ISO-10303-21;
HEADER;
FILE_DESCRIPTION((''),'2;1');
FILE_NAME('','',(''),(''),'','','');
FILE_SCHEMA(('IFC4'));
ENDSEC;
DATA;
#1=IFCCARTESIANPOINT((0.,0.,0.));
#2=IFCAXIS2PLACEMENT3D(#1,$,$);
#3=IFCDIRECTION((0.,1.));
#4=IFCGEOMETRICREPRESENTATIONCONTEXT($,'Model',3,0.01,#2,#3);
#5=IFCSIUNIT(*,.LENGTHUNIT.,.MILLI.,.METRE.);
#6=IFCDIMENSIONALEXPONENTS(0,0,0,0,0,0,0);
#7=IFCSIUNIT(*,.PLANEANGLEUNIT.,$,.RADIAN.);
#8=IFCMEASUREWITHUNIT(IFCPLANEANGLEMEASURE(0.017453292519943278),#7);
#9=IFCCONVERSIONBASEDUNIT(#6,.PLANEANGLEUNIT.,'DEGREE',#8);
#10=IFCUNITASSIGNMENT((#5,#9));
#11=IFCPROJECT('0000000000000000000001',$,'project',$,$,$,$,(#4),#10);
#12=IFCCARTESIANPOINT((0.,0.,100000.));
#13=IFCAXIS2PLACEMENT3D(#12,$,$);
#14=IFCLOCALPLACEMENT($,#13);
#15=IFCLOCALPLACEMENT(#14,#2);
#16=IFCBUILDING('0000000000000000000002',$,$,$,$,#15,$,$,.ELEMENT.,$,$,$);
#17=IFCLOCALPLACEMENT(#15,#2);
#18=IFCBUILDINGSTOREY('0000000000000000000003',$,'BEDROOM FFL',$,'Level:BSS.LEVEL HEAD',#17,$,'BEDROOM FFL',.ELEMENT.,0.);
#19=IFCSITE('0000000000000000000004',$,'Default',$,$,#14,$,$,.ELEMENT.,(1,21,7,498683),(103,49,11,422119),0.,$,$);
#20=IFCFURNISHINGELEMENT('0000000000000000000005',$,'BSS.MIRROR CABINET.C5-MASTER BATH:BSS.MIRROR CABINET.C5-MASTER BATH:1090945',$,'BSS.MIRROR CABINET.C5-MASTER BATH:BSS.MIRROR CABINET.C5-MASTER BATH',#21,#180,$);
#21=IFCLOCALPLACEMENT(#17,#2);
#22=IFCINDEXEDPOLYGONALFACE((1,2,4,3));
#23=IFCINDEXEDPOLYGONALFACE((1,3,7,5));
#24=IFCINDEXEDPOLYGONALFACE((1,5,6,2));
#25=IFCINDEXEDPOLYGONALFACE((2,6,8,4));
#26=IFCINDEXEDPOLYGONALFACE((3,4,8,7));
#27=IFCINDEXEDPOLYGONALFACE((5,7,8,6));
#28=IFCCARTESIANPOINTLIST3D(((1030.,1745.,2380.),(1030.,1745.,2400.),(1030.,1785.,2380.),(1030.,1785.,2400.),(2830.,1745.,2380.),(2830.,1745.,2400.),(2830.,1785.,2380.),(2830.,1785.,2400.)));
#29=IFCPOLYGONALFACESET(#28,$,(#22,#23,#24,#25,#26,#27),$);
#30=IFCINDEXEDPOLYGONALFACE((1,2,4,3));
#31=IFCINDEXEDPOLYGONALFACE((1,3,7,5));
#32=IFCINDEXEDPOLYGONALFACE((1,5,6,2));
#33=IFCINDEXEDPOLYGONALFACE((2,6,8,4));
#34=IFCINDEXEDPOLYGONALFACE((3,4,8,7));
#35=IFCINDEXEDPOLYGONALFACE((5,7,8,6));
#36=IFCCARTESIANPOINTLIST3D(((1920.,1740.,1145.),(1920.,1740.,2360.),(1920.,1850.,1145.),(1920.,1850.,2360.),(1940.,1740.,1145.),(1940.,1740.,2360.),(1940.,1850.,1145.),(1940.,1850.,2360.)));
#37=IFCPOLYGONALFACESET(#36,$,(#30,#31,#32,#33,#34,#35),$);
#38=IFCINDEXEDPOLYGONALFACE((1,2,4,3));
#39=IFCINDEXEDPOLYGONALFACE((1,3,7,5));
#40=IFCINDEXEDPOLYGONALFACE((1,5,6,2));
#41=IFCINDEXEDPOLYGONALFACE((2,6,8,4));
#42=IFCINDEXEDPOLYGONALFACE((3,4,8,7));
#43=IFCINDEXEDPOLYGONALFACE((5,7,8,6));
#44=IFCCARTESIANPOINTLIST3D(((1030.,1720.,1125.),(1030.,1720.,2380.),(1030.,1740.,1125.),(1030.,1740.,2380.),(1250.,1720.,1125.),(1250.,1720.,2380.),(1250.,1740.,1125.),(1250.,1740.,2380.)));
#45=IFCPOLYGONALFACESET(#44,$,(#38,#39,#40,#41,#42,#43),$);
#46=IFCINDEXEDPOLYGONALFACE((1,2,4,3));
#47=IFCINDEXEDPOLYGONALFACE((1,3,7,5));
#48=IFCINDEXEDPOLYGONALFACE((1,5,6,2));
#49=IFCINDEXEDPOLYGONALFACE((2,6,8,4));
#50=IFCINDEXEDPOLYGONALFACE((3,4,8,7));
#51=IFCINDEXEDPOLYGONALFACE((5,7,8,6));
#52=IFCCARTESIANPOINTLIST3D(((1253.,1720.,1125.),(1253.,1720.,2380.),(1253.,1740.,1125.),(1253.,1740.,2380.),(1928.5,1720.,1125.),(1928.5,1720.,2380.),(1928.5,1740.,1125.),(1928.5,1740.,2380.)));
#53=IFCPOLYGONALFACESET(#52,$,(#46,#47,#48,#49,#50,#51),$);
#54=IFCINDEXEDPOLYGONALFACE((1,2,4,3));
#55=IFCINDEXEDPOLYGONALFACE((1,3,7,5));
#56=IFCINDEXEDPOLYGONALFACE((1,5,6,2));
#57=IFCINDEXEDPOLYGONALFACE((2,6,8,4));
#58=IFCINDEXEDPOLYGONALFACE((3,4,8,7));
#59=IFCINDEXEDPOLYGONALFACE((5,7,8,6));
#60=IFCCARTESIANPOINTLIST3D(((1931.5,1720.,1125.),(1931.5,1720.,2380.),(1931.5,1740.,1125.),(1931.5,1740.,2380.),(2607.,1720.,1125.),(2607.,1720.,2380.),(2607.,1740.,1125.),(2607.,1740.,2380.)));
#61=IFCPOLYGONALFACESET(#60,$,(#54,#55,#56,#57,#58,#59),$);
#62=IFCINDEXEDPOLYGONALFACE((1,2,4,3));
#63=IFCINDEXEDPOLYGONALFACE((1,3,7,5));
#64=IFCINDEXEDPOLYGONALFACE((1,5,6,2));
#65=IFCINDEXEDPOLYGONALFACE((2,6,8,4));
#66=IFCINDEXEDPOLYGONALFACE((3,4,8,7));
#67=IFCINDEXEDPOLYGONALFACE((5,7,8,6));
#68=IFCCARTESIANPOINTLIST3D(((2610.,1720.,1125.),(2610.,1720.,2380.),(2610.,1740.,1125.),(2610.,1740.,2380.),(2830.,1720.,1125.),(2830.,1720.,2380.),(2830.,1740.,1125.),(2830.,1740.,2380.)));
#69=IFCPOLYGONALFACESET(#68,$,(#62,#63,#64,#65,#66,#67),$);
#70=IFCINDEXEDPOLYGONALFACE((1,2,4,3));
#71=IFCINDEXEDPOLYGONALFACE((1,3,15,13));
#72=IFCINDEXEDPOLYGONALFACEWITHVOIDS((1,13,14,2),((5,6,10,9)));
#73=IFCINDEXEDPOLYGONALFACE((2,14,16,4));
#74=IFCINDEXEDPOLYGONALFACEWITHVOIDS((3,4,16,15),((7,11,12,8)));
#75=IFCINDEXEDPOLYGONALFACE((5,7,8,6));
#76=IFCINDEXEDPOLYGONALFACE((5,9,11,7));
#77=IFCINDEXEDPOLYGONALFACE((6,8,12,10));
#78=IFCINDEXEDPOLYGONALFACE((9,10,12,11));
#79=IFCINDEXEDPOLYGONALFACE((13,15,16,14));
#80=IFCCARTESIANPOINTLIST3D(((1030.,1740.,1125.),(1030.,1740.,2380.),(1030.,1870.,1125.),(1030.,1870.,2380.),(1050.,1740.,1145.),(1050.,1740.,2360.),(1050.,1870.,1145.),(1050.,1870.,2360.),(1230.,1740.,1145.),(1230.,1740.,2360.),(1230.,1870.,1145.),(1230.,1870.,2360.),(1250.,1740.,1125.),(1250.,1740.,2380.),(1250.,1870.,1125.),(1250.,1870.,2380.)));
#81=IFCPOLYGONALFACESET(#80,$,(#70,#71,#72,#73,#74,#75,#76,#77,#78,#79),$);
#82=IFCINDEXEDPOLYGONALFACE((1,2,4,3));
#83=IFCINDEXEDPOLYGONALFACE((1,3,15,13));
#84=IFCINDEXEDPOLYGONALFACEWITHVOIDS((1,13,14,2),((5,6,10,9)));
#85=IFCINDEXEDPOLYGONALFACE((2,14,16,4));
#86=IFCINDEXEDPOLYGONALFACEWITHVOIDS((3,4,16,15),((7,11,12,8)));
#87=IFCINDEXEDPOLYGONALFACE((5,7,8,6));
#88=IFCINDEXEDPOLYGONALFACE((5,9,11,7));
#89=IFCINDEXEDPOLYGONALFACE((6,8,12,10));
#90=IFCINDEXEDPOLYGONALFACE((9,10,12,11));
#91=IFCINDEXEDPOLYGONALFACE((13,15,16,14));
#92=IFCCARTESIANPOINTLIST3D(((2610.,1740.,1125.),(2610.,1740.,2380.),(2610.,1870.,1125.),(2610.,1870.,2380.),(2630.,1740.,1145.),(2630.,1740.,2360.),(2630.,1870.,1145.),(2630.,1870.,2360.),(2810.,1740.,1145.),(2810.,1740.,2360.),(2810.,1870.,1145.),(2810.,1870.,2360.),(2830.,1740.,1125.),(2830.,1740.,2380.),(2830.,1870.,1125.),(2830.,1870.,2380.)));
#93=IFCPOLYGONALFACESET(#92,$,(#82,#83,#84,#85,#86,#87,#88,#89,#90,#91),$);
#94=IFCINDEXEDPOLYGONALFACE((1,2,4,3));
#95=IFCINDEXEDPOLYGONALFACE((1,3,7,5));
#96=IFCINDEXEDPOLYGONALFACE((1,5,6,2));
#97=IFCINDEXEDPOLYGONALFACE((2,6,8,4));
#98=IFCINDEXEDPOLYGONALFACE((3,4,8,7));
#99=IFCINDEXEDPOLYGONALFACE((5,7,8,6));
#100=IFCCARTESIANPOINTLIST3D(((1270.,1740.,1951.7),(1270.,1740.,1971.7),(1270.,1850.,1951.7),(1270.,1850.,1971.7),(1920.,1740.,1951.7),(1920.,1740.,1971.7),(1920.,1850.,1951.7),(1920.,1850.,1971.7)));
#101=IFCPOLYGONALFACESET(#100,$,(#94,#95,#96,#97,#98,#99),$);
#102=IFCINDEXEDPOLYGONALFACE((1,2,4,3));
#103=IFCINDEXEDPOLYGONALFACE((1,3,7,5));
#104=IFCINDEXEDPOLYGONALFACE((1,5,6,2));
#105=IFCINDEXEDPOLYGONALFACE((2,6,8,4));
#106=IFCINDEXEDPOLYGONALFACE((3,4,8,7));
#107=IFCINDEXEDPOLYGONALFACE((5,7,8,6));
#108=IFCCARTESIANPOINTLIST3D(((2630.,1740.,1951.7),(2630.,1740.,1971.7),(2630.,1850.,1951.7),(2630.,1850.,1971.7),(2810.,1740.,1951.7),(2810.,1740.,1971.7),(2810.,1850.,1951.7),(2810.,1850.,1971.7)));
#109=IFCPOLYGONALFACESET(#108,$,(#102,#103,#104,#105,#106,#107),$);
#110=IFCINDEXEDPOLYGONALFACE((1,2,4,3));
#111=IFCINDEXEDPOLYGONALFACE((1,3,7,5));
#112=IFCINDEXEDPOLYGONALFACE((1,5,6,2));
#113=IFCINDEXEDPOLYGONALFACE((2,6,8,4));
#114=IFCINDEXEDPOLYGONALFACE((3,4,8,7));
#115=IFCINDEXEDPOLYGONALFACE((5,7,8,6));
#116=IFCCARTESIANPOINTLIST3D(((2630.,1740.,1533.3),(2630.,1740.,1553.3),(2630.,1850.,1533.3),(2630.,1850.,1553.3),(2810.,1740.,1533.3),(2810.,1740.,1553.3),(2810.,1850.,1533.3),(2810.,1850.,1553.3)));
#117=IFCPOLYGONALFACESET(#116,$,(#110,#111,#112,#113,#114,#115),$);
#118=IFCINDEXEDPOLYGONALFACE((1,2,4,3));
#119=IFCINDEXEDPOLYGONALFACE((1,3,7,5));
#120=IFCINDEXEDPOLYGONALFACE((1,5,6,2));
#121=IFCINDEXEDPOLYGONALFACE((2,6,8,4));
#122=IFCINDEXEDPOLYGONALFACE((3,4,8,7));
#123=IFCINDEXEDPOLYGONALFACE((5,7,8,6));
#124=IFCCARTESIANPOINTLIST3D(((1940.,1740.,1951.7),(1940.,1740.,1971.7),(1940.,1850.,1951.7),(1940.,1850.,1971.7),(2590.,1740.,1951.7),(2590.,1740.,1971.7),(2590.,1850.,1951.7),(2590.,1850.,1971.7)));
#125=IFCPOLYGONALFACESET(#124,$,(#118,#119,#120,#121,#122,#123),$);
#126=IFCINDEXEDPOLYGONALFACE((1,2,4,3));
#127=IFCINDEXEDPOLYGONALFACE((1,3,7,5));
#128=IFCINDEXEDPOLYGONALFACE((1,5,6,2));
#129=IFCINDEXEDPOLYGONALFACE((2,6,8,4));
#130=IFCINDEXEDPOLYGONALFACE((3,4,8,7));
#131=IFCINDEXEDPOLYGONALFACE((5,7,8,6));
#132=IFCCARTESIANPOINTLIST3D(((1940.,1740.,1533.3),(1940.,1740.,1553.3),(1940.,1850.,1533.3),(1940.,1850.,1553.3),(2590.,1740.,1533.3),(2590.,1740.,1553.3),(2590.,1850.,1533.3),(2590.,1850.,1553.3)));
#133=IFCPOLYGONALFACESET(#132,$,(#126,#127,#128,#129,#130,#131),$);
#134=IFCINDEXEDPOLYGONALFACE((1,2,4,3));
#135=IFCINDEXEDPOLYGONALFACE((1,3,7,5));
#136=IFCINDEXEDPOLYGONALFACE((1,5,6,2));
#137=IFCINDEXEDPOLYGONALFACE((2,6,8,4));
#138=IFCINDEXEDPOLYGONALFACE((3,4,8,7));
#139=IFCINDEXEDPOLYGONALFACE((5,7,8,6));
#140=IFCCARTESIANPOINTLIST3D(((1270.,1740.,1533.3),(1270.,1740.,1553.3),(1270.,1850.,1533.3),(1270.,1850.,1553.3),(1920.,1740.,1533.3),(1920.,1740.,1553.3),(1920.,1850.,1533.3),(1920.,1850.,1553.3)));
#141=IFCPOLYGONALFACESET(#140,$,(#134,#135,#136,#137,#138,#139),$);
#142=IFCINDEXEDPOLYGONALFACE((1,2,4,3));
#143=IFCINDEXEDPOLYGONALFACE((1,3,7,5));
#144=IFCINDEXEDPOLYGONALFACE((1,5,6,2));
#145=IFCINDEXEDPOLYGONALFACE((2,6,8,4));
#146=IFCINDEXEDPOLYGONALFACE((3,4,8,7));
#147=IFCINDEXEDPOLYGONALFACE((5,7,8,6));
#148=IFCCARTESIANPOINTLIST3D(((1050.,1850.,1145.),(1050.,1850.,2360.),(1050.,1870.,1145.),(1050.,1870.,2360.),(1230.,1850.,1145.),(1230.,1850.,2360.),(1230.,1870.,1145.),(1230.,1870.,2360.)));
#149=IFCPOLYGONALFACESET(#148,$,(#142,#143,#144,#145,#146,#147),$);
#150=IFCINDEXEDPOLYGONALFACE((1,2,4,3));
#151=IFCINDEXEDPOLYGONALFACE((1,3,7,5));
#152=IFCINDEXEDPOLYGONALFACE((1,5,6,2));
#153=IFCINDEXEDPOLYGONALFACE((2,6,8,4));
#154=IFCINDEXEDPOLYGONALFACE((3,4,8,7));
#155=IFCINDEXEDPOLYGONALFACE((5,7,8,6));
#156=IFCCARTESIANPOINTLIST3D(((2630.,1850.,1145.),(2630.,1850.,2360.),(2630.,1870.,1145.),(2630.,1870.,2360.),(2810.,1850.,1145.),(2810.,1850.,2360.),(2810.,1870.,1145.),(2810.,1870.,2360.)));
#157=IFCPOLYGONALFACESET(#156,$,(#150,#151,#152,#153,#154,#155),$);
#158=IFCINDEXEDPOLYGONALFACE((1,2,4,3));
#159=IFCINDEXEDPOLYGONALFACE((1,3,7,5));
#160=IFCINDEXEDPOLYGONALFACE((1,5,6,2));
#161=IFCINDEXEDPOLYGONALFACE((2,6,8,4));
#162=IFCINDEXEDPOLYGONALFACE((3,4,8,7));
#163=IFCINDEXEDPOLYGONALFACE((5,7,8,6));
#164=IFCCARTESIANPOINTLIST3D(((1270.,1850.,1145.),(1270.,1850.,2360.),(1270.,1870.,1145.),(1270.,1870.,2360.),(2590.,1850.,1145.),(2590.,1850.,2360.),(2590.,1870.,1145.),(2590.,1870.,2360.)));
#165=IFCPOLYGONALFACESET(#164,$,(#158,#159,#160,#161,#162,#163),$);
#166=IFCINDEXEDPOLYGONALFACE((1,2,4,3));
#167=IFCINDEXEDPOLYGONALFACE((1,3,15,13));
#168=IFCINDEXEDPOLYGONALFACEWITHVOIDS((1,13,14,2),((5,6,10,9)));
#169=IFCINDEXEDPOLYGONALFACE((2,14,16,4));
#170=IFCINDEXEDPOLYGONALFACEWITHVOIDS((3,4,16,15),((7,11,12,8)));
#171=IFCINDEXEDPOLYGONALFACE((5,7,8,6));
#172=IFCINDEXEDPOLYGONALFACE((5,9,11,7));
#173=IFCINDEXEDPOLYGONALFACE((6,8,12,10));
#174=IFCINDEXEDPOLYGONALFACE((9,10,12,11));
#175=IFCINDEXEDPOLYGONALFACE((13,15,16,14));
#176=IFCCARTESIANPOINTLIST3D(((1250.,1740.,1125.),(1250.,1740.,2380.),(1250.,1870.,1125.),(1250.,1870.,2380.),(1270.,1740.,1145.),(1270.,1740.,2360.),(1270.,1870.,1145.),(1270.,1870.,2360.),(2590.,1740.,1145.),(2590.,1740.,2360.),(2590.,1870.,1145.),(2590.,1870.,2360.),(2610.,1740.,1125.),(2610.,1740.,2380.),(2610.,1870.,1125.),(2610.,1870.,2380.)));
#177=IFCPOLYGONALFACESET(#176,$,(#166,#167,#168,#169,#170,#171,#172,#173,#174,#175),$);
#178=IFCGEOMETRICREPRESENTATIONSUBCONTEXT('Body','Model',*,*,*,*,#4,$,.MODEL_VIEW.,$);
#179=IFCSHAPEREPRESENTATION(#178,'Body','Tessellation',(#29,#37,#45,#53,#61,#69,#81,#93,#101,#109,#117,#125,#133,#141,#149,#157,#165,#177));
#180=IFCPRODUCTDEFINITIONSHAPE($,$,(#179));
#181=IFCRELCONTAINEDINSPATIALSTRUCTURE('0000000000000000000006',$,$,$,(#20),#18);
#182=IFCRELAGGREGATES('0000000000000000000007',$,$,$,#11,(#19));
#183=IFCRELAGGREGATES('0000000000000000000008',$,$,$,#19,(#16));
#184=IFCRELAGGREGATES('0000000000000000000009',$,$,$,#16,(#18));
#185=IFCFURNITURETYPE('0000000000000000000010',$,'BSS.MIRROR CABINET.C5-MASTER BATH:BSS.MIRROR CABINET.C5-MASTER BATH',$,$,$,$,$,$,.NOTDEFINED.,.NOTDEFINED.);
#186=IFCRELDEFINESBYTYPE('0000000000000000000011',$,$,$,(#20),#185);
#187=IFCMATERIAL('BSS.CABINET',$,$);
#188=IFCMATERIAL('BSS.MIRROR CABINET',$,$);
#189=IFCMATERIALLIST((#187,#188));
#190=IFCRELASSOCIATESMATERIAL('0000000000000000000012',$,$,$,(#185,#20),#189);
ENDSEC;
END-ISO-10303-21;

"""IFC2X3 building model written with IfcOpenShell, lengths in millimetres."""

from ifc_helpers import new_model, entity, si_unit, converted_unit, direction, frame, frame_2d, origin, origin_2d_with_axis, place, context, subcontext, project, spatial, polyline, rectangle, outline, extrude, source, transform, mapped, material, material_list, type_object, type_shapes, element, save


model = new_model("IFC2X3")

# Units and contexts
model_context = context("Model", 3, precision=0.01, world=origin(), true_north=direction((0.0, 1.0)))
body_context = subcontext(model_context, "Body", "Model", "MODEL_VIEW")
ifc_project = project(units=[si_unit("LENGTHUNIT", "METRE", prefix="MILLI"), converted_unit("PLANEANGLEUNIT", "DEGREE", entity("IfcPlaneAngleMeasure", 0.017453292519943278), si_unit("PLANEANGLEUNIT", "RADIAN"), dimensions=[0, 0, 0, 0, 0, 0, 0])], contexts=[model_context])

# Site, building, storey
site_placement = place(None, frame((0.0, 0.0, 100000.0)))
site = spatial("IfcSite", under=ifc_project, at=site_placement, Name="Default", CompositionType="ELEMENT", RefLatitude=(1, 21, 7, 498683), RefLongitude=(103, 49, 11, 422119), RefElevation=0.0)
building_placement = place(site_placement, origin())
building = spatial("IfcBuilding", under=site, at=building_placement, CompositionType="ELEMENT")
storey_placement = place(building_placement, origin())
storey = spatial("IfcBuildingStorey", under=building, at=storey_placement, Name="BEDROOM FFL", ObjectType="Level:BSS.LEVEL HEAD", LongName="BEDROOM FFL", CompositionType="ELEMENT", Elevation=0.0)

# Furnishing element
ifc_material_1 = material(Name="BSS.CABINET")
ifc_material_2 = material(Name="BSS.MIRROR CABINET")
ifc_material_list = material_list([ifc_material_1, ifc_material_2])
furniture_type = type_object("IfcFurnitureType", Name="BSS.MIRROR CABINET.C5-MASTER BATH:BSS.MIRROR CABINET.C5-MASTER BATH", AssemblyPlace="NOTDEFINED", material=ifc_material_list)
shared_shape_1 = source(origin(), body_context, "Body", "SweptSolid", [
    extrude(rectangle(XDim=40.0, YDim=1800.0, at=frame_2d((0.0, 0.0), x_axis=(1.0, 0.0))), frame((0.0, 105.0, 1255.0), z_axis=(0.0, 0.0, 1.0), x_axis=(0.0, 1.0, 0.0)), (0.0, 0.0, 1.0), 20.0),
    extrude(rectangle(XDim=20.0, YDim=110.0, at=frame_2d((0.0, 0.0), x_axis=(1.0, 0.0))), frame((0.0, 75.0, 20.0), z_axis=(0.0, 0.0, 1.0), x_axis=(-1.0, 0.0, 0.0)), (0.0, 0.0, 1.0), 1215.0),
    extrude(rectangle(XDim=220.0, YDim=20.0, at=frame_2d((0.0, 0.0), x_axis=(1.0, 0.0))), frame((790.0, 140.0, 0.0), z_axis=(0.0, 0.0, 1.0), x_axis=(-1.0, 0.0, 0.0)), (0.0, 0.0, 1.0), 1255.0),
    extrude(rectangle(XDim=675.5, YDim=20.0, at=frame_2d((0.0, 0.0), x_axis=(1.0, 0.0))), frame((339.2, 140.0, 0.0), z_axis=(0.0, 0.0, 1.0), x_axis=(-1.0, 0.0, 0.0)), (0.0, 0.0, 1.0), 1255.0),
    extrude(rectangle(XDim=675.5, YDim=20.0, at=frame_2d((0.0, 0.0), x_axis=(1.0, 0.0))), frame((-339.3, 140.0, 0.0), z_axis=(0.0, 0.0, 1.0), x_axis=(-1.0, 0.0, 0.0)), (0.0, 0.0, 1.0), 1255.0),
    extrude(rectangle(XDim=220.0, YDim=20.0, at=frame_2d((0.0, 0.0), x_axis=(1.0, 0.0))), frame((-790.0, 140.0, 0.0), z_axis=(0.0, 0.0, 1.0), x_axis=(-1.0, 0.0, 0.0)), (0.0, 0.0, 1.0), 1255.0),
    extrude(outline(polyline([(-627.5, -110.0), (627.5, -110.0), (627.5, 110.0), (-627.5, 110.0), (-627.5, -110.0)]), holes=[polyline([(607.5, 90.0), (607.5, -90.0), (-607.5, -90.0), (-607.5, 90.0), (607.5, 90.0)])]), frame((790.0, 0.0, 627.5), z_axis=(0.0, 1.0, 0.0), x_axis=(0.0, 0.0, -1.0)), (0.0, 0.0, 1.0), 130.0),
    extrude(outline(polyline([(-627.5, -110.0), (627.5, -110.0), (627.5, 110.0), (-627.5, 110.0), (-627.5, -110.0)]), holes=[polyline([(607.5, 90.0), (607.5, -90.0), (-607.5, -90.0), (-607.5, 90.0), (607.5, 90.0)])]), frame((-790.0, 0.0, 627.5), z_axis=(0.0, 1.0, 0.0), x_axis=(0.0, 0.0, -1.0)), (0.0, 0.0, 1.0), 130.0),
    extrude(rectangle(XDim=650.0, YDim=110.0, at=origin_2d_with_axis()), frame((335.0, 75.0, 826.7), z_axis=(0.0, 0.0, 1.0), x_axis=(-1.0, 0.0, 0.0)), (0.0, 0.0, 1.0), 20.0),
    extrude(rectangle(XDim=180.0, YDim=110.0, at=origin_2d_with_axis()), frame((-790.0, 75.0, 826.7), z_axis=(0.0, 0.0, 1.0), x_axis=(-1.0, 0.0, 0.0)), (0.0, 0.0, 1.0), 20.0),
    extrude(rectangle(XDim=180.0, YDim=110.0, at=origin_2d_with_axis()), frame((-790.0, 75.0, 408.3), z_axis=(0.0, 0.0, 1.0), x_axis=(-1.0, 0.0, 0.0)), (0.0, 0.0, 1.0), 20.0),
    extrude(rectangle(XDim=650.0, YDim=110.0, at=origin_2d_with_axis()), frame((-335.0, 75.0, 826.7), z_axis=(0.0, 0.0, 1.0), x_axis=(-1.0, 0.0, 0.0)), (0.0, 0.0, 1.0), 20.0),
    extrude(rectangle(XDim=650.0, YDim=110.0, at=frame_2d((0.0, 0.0), x_axis=(1.0, 0.0))), frame((-335.0, 75.0, 408.3), z_axis=(0.0, 0.0, 1.0), x_axis=(-1.0, 0.0, 0.0)), (0.0, 0.0, 1.0), 20.0),
    extrude(rectangle(XDim=650.0, YDim=110.0, at=origin_2d_with_axis()), frame((335.0, 75.0, 408.3), z_axis=(0.0, 0.0, 1.0), x_axis=(-1.0, 0.0, 0.0)), (0.0, 0.0, 1.0), 20.0),
    extrude(rectangle(XDim=180.0, YDim=20.0, at=origin_2d_with_axis()), frame((790.0, 10.0, 20.0), z_axis=(0.0, 0.0, 1.0), x_axis=(-1.0, 0.0, 0.0)), (0.0, 0.0, 1.0), 1215.0),
    extrude(rectangle(XDim=180.0, YDim=20.0, at=origin_2d_with_axis()), frame((-790.0, 10.0, 20.0), z_axis=(0.0, 0.0, 1.0), x_axis=(-1.0, 0.0, 0.0)), (0.0, 0.0, 1.0), 1215.0),
    extrude(rectangle(XDim=1320.0, YDim=20.0, at=origin_2d_with_axis()), frame((0.0, 10.0, 20.0), z_axis=(0.0, 0.0, 1.0), x_axis=(-1.0, 0.0, 0.0)), (0.0, 0.0, 1.0), 1215.0),
    extrude(outline(polyline([(-680.0, -627.5), (680.0, -627.5), (680.0, 627.5), (-680.0, 627.5), (-680.0, -627.5)]), holes=[polyline([(660.0, 607.5), (660.0, -607.5), (-660.0, -607.5), (-660.0, 607.5), (660.0, 607.5)])]), frame((0.0, 0.0, 627.5), z_axis=(0.0, 1.0, 0.0), x_axis=(-1.0, 0.0, 0.0)), (0.0, 0.0, 1.0), 130.0),
])
type_shapes(furniture_type, [shared_shape_1])
furnishing_placement = place(storey_placement, frame((1930.0, 1870.0, 1125.0), z_axis=(0.0, 0.0, 1.0), x_axis=(-1.0, 0.0, 0.0)))
element("IfcFurnishingElement", 1, at=furnishing_placement, inside=storey, type_object=furniture_type, material=ifc_material_list, Name="BSS.MIRROR CABINET.C5-MASTER BATH:BSS.MIRROR CABINET.C5-MASTER BATH:1090945", ObjectType="BSS.MIRROR CABINET.C5-MASTER BATH:BSS.MIRROR CABINET.C5-MASTER BATH", context=body_context, shape_type="MappedRepresentation", body=[
    mapped(shared_shape_1, transform((0.0, 0.0, 0.0), scale=1.0)),
])

save(model, "model.ifc")
